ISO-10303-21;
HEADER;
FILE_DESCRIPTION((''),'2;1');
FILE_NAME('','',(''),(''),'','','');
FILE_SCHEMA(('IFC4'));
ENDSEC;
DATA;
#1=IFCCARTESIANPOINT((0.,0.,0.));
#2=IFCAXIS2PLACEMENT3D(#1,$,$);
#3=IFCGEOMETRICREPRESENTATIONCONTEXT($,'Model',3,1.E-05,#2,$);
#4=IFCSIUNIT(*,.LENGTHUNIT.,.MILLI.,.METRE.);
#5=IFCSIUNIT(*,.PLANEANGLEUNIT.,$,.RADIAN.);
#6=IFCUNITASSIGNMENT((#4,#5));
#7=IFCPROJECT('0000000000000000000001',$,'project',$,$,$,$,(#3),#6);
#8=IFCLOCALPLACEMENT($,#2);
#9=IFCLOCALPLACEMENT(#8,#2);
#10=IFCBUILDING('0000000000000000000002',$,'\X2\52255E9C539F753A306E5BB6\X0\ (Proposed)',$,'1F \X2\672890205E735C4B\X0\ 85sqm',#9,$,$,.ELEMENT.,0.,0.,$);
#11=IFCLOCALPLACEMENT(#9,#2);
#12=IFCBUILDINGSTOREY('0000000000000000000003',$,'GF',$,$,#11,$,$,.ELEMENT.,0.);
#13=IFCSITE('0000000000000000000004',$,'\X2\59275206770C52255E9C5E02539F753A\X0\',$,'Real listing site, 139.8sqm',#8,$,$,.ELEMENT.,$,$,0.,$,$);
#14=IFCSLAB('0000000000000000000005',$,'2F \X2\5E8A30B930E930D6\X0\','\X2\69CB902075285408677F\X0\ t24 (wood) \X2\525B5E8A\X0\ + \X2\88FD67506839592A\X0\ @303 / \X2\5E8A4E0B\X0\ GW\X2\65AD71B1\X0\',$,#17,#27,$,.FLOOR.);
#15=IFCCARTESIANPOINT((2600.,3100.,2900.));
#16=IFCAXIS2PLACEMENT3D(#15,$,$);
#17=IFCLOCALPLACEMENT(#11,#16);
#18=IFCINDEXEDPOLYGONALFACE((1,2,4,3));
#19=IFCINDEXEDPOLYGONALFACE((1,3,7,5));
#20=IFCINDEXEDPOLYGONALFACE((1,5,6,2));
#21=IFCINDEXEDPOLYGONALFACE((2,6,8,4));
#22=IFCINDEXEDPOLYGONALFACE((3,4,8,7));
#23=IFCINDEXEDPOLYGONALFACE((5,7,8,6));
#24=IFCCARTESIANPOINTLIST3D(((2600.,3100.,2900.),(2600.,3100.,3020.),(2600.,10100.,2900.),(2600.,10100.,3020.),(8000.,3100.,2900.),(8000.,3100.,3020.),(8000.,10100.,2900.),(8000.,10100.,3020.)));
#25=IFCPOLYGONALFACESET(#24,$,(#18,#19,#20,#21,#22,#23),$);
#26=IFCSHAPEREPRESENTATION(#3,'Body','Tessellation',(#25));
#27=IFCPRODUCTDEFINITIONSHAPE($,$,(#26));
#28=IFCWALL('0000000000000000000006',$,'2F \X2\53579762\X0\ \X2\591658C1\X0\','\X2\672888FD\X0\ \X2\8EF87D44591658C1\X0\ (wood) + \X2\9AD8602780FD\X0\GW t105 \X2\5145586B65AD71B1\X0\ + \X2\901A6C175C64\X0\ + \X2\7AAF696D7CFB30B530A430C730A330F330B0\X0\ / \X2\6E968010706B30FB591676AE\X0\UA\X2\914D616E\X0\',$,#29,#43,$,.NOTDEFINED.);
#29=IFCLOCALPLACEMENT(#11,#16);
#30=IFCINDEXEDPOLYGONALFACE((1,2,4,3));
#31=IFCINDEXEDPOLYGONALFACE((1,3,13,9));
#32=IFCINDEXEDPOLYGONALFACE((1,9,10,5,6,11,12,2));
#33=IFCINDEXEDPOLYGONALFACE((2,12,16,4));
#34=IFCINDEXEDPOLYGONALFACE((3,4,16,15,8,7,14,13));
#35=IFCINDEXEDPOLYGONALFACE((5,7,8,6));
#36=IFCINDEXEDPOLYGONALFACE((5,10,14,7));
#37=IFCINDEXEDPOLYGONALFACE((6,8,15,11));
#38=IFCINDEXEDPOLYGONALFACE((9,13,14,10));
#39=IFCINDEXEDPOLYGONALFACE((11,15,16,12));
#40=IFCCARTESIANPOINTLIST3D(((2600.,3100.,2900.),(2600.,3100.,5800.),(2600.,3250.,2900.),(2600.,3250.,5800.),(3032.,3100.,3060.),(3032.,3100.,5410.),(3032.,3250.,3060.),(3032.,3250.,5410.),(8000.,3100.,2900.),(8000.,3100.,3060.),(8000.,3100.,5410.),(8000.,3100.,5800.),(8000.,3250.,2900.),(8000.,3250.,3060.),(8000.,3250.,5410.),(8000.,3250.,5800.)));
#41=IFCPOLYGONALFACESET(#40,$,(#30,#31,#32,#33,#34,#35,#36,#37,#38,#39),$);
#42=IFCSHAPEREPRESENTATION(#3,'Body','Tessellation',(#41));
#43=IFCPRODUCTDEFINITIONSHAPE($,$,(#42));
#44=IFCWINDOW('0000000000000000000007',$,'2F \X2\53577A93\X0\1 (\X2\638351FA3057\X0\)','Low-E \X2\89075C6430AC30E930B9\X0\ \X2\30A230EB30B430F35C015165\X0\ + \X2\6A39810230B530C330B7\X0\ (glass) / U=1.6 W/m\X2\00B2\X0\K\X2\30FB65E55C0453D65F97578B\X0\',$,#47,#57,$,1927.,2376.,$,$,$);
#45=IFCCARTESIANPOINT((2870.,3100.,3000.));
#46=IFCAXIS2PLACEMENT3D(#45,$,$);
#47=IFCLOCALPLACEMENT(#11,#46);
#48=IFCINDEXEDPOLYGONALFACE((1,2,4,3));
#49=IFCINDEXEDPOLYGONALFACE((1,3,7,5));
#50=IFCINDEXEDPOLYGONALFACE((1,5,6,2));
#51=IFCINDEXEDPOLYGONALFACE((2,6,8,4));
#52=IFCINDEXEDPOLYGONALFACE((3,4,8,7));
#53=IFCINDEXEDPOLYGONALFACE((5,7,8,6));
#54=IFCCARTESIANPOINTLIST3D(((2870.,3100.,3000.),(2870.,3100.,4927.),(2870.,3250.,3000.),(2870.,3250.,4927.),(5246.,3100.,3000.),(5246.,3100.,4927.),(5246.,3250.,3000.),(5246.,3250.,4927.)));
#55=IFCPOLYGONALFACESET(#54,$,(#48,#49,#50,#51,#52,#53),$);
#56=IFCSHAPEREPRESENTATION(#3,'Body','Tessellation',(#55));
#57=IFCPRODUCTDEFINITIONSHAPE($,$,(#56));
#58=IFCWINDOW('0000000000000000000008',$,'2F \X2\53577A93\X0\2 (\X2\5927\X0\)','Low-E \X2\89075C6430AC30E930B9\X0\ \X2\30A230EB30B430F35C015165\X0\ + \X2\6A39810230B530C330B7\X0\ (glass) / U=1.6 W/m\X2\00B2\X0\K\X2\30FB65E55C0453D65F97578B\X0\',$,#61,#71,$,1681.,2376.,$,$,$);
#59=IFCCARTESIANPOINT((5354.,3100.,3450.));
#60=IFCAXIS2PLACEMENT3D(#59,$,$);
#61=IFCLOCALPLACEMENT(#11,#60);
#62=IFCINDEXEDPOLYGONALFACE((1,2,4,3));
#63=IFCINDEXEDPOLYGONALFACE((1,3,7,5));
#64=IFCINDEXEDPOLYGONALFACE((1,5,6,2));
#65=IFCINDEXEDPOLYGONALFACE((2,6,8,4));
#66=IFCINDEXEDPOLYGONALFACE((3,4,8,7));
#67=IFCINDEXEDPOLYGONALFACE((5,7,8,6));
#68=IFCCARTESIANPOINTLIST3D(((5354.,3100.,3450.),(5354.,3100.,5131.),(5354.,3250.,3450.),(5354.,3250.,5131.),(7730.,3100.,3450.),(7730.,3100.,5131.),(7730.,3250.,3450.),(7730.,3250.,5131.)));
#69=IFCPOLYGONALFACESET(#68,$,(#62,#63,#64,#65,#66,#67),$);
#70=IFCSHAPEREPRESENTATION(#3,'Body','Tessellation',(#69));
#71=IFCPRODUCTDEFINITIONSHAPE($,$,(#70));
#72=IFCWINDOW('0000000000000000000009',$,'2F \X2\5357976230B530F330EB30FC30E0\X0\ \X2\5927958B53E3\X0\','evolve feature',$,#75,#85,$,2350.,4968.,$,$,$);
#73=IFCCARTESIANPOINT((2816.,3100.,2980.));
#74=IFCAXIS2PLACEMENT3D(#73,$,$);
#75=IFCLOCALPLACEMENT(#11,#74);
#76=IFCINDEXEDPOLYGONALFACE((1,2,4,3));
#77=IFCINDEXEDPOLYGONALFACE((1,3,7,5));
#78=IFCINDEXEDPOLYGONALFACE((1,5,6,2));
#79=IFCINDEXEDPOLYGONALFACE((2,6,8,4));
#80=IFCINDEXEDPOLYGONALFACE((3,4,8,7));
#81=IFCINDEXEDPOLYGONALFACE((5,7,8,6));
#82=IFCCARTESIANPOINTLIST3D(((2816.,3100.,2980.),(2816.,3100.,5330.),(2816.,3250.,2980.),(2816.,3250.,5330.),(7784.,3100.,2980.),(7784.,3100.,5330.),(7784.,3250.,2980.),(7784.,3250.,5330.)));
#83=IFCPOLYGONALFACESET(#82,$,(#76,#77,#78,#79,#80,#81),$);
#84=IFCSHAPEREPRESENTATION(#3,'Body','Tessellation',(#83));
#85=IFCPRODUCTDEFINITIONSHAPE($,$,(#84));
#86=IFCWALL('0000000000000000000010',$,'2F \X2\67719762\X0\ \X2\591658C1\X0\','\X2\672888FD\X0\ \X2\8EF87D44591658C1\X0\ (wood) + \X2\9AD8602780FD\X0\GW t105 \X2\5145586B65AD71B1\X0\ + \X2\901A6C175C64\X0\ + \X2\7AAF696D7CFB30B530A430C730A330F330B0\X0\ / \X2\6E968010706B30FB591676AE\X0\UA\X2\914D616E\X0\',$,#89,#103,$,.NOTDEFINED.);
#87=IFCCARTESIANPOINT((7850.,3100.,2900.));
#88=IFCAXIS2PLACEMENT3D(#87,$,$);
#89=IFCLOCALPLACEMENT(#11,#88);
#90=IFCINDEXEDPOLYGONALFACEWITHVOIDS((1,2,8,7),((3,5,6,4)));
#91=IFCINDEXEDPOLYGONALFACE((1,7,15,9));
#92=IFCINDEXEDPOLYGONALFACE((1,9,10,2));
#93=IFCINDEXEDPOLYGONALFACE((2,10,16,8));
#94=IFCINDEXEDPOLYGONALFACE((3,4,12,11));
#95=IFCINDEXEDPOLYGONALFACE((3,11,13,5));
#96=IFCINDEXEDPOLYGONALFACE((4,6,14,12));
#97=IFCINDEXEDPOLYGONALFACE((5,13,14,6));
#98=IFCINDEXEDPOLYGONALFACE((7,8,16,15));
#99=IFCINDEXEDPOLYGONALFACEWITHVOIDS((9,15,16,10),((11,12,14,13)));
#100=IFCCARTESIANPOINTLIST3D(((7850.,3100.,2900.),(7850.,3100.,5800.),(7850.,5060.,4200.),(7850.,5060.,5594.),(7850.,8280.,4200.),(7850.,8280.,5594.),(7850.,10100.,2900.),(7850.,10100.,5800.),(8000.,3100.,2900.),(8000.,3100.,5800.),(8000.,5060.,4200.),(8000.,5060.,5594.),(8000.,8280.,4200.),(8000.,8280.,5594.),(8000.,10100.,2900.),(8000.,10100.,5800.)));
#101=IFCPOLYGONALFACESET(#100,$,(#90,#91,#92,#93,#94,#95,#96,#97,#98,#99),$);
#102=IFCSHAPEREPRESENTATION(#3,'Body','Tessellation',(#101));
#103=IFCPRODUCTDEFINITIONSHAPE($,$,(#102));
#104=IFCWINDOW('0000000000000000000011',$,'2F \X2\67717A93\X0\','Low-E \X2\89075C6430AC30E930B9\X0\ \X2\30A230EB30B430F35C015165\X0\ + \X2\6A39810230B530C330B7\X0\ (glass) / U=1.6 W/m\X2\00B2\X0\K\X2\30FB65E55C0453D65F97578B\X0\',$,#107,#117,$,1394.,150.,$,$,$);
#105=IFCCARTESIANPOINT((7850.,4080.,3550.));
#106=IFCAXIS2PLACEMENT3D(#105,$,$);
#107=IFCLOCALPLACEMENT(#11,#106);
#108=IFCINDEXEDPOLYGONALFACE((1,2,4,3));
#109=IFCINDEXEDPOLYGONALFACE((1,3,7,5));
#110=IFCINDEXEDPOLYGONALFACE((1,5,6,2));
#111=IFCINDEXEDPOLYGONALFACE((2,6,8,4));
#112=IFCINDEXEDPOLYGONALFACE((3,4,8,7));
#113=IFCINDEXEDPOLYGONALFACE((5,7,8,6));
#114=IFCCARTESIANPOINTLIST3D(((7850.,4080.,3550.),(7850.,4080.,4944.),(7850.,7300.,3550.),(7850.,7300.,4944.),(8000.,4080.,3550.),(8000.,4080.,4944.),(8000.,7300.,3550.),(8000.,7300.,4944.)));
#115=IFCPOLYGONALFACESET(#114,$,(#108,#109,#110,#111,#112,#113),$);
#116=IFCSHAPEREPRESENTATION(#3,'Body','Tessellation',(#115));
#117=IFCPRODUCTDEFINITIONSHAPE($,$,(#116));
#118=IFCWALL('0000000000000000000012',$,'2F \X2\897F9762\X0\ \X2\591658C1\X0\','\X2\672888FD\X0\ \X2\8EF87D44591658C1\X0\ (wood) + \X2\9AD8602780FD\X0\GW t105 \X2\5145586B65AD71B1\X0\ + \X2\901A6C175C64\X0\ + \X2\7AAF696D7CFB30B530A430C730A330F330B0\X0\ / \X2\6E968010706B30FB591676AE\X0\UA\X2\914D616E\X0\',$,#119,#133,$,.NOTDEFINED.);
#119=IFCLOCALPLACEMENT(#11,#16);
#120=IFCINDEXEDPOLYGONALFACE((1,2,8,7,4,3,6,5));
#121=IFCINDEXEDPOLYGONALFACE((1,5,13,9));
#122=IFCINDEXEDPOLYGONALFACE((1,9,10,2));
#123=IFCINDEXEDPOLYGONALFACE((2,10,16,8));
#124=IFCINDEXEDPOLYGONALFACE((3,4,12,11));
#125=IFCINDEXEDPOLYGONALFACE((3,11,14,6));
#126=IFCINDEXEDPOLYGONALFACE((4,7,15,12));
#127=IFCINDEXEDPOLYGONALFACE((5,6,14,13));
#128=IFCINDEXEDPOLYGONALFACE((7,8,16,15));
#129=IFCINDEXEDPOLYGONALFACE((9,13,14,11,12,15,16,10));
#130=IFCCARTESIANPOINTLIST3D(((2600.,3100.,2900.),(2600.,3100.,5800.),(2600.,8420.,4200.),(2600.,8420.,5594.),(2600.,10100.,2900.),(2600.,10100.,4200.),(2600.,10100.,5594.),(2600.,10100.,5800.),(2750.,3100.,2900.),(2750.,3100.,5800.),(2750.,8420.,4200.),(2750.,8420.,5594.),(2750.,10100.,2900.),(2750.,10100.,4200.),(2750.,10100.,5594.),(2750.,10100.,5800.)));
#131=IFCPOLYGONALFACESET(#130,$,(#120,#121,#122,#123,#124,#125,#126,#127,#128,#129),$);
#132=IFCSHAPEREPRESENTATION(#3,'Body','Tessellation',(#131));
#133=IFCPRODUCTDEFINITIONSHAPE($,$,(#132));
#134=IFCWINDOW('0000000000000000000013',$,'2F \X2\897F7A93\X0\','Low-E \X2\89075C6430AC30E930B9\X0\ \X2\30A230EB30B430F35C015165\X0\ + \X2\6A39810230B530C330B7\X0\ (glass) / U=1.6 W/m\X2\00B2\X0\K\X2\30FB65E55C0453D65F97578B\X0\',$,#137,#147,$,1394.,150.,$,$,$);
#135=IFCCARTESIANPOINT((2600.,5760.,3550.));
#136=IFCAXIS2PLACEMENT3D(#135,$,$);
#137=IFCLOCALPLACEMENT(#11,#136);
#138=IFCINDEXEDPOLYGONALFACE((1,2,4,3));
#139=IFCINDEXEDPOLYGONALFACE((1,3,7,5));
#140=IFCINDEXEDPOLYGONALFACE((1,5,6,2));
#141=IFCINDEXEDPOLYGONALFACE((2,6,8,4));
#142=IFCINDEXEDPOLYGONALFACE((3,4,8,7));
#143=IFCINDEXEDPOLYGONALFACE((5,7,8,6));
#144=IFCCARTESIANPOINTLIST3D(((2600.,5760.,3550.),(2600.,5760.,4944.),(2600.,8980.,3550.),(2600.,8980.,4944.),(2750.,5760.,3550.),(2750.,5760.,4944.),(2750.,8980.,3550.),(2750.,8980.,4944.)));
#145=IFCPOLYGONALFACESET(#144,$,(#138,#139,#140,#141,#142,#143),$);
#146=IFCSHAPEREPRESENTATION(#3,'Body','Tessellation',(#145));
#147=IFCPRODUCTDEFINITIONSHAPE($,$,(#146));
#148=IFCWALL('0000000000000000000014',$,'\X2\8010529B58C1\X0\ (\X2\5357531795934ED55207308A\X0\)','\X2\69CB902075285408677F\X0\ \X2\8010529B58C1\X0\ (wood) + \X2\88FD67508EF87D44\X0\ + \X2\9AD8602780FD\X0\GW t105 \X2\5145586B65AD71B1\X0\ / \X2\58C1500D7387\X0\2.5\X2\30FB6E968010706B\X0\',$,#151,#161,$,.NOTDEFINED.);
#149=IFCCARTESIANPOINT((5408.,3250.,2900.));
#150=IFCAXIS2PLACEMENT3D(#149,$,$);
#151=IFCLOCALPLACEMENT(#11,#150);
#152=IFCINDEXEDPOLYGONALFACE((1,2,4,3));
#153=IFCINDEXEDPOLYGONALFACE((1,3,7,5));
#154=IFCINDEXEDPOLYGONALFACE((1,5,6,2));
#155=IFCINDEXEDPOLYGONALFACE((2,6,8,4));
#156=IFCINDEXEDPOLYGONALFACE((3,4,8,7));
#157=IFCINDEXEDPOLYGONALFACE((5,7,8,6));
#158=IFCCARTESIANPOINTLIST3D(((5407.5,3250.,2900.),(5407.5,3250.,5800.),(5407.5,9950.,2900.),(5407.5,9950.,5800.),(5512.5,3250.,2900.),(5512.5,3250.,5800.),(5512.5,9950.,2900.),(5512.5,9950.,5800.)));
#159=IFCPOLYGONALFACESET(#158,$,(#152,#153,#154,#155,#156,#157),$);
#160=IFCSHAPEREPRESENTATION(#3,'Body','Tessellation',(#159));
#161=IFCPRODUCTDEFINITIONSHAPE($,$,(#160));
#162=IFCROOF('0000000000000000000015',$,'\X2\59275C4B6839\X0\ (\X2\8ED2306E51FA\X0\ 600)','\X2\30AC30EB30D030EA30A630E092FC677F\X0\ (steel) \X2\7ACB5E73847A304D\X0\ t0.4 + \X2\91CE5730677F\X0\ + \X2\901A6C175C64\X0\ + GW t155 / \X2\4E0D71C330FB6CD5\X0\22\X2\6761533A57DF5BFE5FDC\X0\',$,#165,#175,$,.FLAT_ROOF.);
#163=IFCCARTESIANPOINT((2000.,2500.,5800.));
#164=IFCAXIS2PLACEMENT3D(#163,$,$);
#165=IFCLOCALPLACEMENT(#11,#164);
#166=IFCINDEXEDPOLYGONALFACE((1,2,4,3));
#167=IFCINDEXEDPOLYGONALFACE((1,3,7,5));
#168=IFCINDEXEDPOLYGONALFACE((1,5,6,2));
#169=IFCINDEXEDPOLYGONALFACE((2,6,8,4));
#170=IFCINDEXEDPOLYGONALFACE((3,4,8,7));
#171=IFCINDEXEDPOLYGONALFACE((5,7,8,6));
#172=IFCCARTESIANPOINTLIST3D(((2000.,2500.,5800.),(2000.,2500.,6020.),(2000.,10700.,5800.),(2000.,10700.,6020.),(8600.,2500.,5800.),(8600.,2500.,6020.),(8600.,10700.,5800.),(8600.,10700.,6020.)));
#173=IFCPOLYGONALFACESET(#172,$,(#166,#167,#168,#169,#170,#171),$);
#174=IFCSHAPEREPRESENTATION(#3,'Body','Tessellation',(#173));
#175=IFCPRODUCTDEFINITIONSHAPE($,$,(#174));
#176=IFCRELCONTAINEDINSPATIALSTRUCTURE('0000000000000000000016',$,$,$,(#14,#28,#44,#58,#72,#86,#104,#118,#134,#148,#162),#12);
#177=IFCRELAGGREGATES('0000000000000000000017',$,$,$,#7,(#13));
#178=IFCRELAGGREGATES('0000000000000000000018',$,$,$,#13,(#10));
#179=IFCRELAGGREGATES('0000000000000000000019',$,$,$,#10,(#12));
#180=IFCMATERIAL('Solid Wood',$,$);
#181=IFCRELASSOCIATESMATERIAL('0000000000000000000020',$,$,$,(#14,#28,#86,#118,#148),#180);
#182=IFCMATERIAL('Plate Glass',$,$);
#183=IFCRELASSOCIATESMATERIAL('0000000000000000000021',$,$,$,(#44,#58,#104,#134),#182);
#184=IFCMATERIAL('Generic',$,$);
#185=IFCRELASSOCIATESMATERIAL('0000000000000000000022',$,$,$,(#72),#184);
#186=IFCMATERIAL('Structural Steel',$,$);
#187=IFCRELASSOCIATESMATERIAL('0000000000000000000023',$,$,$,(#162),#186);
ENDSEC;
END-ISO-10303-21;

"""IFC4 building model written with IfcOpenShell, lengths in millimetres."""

from ifc_helpers import new_model, si_unit, frame, frame_2d, origin, place, context, project, spatial, rectangle, extrude, material, element, fill, save


model = new_model("IFC4")

# Units and contexts
model_context = context("Model", 3, precision=1e-05, world=origin())
ifc_project = project(units=[si_unit("LENGTHUNIT", "METRE", prefix="MILLI"), si_unit("PLANEANGLEUNIT", "RADIAN")], contexts=[model_context])

# Site, building, storey
site_placement = place(None, origin())
site = spatial("IfcSite", under=ifc_project, at=site_placement, Name="大分県別府市原町", ObjectType="Real listing site, 139.8sqm", CompositionType="ELEMENT", RefElevation=0.0)
building_placement = place(site_placement, origin())
building = spatial("IfcBuilding", under=site, at=building_placement, Name="別府原町の家 (Proposed)", ObjectType="1F 木造平屋 85sqm", CompositionType="ELEMENT", ElevationOfRefHeight=0.0, ElevationOfTerrain=0.0)
storey_placement = place(building_placement, origin())
storey = spatial("IfcBuildingStorey", under=building, at=storey_placement, Name="GF", CompositionType="ELEMENT", Elevation=0.0)

# Slab
ifc_material_1 = material(Name="Solid Wood")
slab_placement = place(storey_placement, frame((2600.0, 3100.0, 2900.0)))
element("IfcSlab", 1, at=slab_placement, inside=storey, material=ifc_material_1, Name="2F 床スラブ", Description="構造用合板 t24 (wood) 剛床 + 製材根太 @303 / 床下 GW断熱", PredefinedType="FLOOR", context=model_context, shape_type="SweptSolid", body=[
    extrude(rectangle(XDim=5400.0, YDim=7000.0, at=frame_2d((2700.0, 3500.0))), frame((2600.0, 3100.0, 2900.0)), (0.0, 0.0, 1.0), 120.0),
])

# Wall, openings, windows
wall_1_placement = place(storey_placement, frame((2600.0, 3100.0, 2900.0)))
wall_1 = element("IfcWall", 2, at=wall_1_placement, inside=storey, material=ifc_material_1, Name="2F 南面 外壁", Description="木製 軸組外壁 (wood) + 高性能GW t105 充填断熱 + 通気層 + 窯業系サイディング / 準耐火・外皮UA配慮", PredefinedType="NOTDEFINED", context=model_context, shape_type="SweptSolid", body=[
    extrude(rectangle(XDim=5400.0, YDim=150.0, at=frame_2d((2700.0, 75.0))), frame((2600.0, 3100.0, 2900.0)), (0.0, 0.0, 1.0), 2900.0),
])
opening_1_placement = place(storey_placement, frame((2870.0, 3100.0, 3000.0)))
opening_1 = element("IfcOpeningElement", 3, at=opening_1_placement, cuts=wall_1, PredefinedType="NOTDEFINED", context=model_context, shape_type="SweptSolid", body=[
    extrude(rectangle(XDim=2376.0, YDim=150.0, at=frame_2d((1188.0, 75.0))), frame((2870.0, 3100.0, 3000.0)), (0.0, 0.0, 1.0), 1927.0),
])
opening_2_placement = place(storey_placement, frame((5354.0, 3100.0, 3450.0)))
opening_2 = element("IfcOpeningElement", 4, at=opening_2_placement, cuts=wall_1, PredefinedType="NOTDEFINED", context=model_context, shape_type="SweptSolid", body=[
    extrude(rectangle(XDim=2376.0, YDim=150.0, at=frame_2d((1188.0, 75.0))), frame((5354.0, 3100.0, 3450.0)), (0.0, 0.0, 1.0), 1681.0),
])
opening_3_placement = place(storey_placement, frame((2816.0, 3100.0, 2980.0)))
opening_3 = element("IfcOpeningElement", 5, at=opening_3_placement, cuts=wall_1, PredefinedType="NOTDEFINED", context=model_context, shape_type="SweptSolid", body=[
    extrude(rectangle(XDim=4968.0, YDim=150.0, at=frame_2d((2484.0, 75.0))), frame((2816.0, 3100.0, 2980.0)), (0.0, 0.0, 1.0), 2350.0),
])
ifc_material_2 = material(Name="Plate Glass")
window_1_placement = place(storey_placement, frame((2870.0, 3100.0, 3000.0)))
window_1 = element("IfcWindow", 6, at=window_1_placement, inside=storey, material=ifc_material_2, Name="2F 南窓1 (掃出し)", Description="Low-E 複層ガラス アルゴン封入 + 樹脂サッシ (glass) / U=1.6 W/m²K・日射取得型", OverallHeight=1927.0, OverallWidth=2376.0, context=model_context, shape_type="SweptSolid", body=[
    extrude(rectangle(XDim=2376.0, YDim=150.0, at=frame_2d((1188.0, 75.0))), frame((2870.0, 3100.0, 3000.0)), (0.0, 0.0, 1.0), 1927.0),
])
fill(opening_1, window_1)
window_2_placement = place(storey_placement, frame((5354.0, 3100.0, 3450.0)))
window_2 = element("IfcWindow", 7, at=window_2_placement, inside=storey, material=ifc_material_2, Name="2F 南窓2 (大)", Description="Low-E 複層ガラス アルゴン封入 + 樹脂サッシ (glass) / U=1.6 W/m²K・日射取得型", OverallHeight=1681.0, OverallWidth=2376.0, context=model_context, shape_type="SweptSolid", body=[
    extrude(rectangle(XDim=2376.0, YDim=150.0, at=frame_2d((1188.0, 75.0))), frame((5354.0, 3100.0, 3450.0)), (0.0, 0.0, 1.0), 1681.0),
])
fill(opening_2, window_2)
ifc_material_3 = material(Name="Generic")
window_3_placement = place(storey_placement, frame((2816.0, 3100.0, 2980.0)))
window_3 = element("IfcWindow", 8, at=window_3_placement, inside=storey, material=ifc_material_3, Name="2F 南面サンルーム 大開口", Description="evolve feature", OverallHeight=2350.0, OverallWidth=4968.0, context=model_context, shape_type="SweptSolid", body=[
    extrude(rectangle(XDim=4968.0, YDim=150.0, at=frame_2d((2484.0, 75.0))), frame((2816.0, 3100.0, 2980.0)), (0.0, 0.0, 1.0), 2350.0),
])
fill(opening_3, window_3)

# Walls, openings, windows
wall_2_placement = place(storey_placement, frame((7850.0, 3100.0, 2900.0)))
wall_2 = element("IfcWall", 9, at=wall_2_placement, inside=storey, material=ifc_material_1, Name="2F 東面 外壁", Description="木製 軸組外壁 (wood) + 高性能GW t105 充填断熱 + 通気層 + 窯業系サイディング / 準耐火・外皮UA配慮", PredefinedType="NOTDEFINED", context=model_context, shape_type="SweptSolid", body=[
    extrude(rectangle(XDim=150.0, YDim=7000.0, at=frame_2d((75.0, 3500.0))), frame((7850.0, 3100.0, 2900.0)), (0.0, 0.0, 1.0), 2900.0),
])
opening_4_placement = place(storey_placement, frame((7850.0, 4080.0, 3550.0)))
opening_4 = element("IfcOpeningElement", 10, at=opening_4_placement, cuts=wall_2, PredefinedType="NOTDEFINED", context=model_context, shape_type="SweptSolid", body=[
    extrude(rectangle(XDim=150.0, YDim=3220.0, at=frame_2d((75.0, 1610.0))), frame((7850.0, 4080.0, 3550.0)), (0.0, 0.0, 1.0), 1394.0),
])
window_4_placement = place(storey_placement, frame((7850.0, 4080.0, 3550.0)))
window_4 = element("IfcWindow", 11, at=window_4_placement, inside=storey, material=ifc_material_2, Name="2F 東窓", Description="Low-E 複層ガラス アルゴン封入 + 樹脂サッシ (glass) / U=1.6 W/m²K・日射取得型", OverallHeight=1394.0, OverallWidth=150.0, context=model_context, shape_type="SweptSolid", body=[
    extrude(rectangle(XDim=150.0, YDim=3220.0, at=frame_2d((75.0, 1610.0))), frame((7850.0, 4080.0, 3550.0)), (0.0, 0.0, 1.0), 1394.0),
])
fill(opening_4, window_4)
wall_3_placement = place(storey_placement, frame((2600.0, 3100.0, 2900.0)))
wall_3 = element("IfcWall", 12, at=wall_3_placement, inside=storey, material=ifc_material_1, Name="2F 西面 外壁", Description="木製 軸組外壁 (wood) + 高性能GW t105 充填断熱 + 通気層 + 窯業系サイディング / 準耐火・外皮UA配慮", PredefinedType="NOTDEFINED", context=model_context, shape_type="SweptSolid", body=[
    extrude(rectangle(XDim=150.0, YDim=7000.0, at=frame_2d((75.0, 3500.0))), frame((2600.0, 3100.0, 2900.0)), (0.0, 0.0, 1.0), 2900.0),
])
opening_5_placement = place(storey_placement, frame((2600.0, 5760.0, 3550.0)))
opening_5 = element("IfcOpeningElement", 13, at=opening_5_placement, cuts=wall_3, PredefinedType="NOTDEFINED", context=model_context, shape_type="SweptSolid", body=[
    extrude(rectangle(XDim=150.0, YDim=3220.0, at=frame_2d((75.0, 1610.0))), frame((2600.0, 5760.0, 3550.0)), (0.0, 0.0, 1.0), 1394.0),
])
window_5_placement = place(storey_placement, frame((2600.0, 5760.0, 3550.0)))
window_5 = element("IfcWindow", 14, at=window_5_placement, inside=storey, material=ifc_material_2, Name="2F 西窓", Description="Low-E 複層ガラス アルゴン封入 + 樹脂サッシ (glass) / U=1.6 W/m²K・日射取得型", OverallHeight=1394.0, OverallWidth=150.0, context=model_context, shape_type="SweptSolid", body=[
    extrude(rectangle(XDim=150.0, YDim=3220.0, at=frame_2d((75.0, 1610.0))), frame((2600.0, 5760.0, 3550.0)), (0.0, 0.0, 1.0), 1394.0),
])
fill(opening_5, window_5)

# Wall
wall_4_placement = place(storey_placement, frame((5408.0, 3250.0, 2900.0)))
element("IfcWall", 15, at=wall_4_placement, inside=storey, material=ifc_material_1, Name="耐力壁 (南北間仕切り)", Description="構造用合板 耐力壁 (wood) + 製材軸組 + 高性能GW t105 充填断熱 / 壁倍率2.5・準耐火", PredefinedType="NOTDEFINED", context=model_context, shape_type="SweptSolid", body=[
    extrude(rectangle(XDim=105.0, YDim=6700.0, at=frame_2d((52.0, 3350.0))), frame((5408.0, 3250.0, 2900.0)), (0.0, 0.0, 1.0), 2900.0),
])

# Roof
ifc_material_4 = material(Name="Structural Steel")
roof_1_placement = place(storey_placement, frame((2000.0, 2500.0, 5800.0)))
element("IfcRoof", 16, at=roof_1_placement, inside=storey, material=ifc_material_4, Name="大屋根 (軒の出 600)", Description="ガルバリウム鋼板 (steel) 立平葺き t0.4 + 野地板 + 通気層 + GW t155 / 不燃・法22条区域対応", PredefinedType="FLAT_ROOF", context=model_context, shape_type="SweptSolid", body=[
    extrude(rectangle(XDim=6600.0, YDim=8200.0, at=frame_2d((3300.0, 4100.0))), frame((2000.0, 2500.0, 5800.0)), (0.0, 0.0, 1.0), 220.0),
])

save(model, "model.ifc")
